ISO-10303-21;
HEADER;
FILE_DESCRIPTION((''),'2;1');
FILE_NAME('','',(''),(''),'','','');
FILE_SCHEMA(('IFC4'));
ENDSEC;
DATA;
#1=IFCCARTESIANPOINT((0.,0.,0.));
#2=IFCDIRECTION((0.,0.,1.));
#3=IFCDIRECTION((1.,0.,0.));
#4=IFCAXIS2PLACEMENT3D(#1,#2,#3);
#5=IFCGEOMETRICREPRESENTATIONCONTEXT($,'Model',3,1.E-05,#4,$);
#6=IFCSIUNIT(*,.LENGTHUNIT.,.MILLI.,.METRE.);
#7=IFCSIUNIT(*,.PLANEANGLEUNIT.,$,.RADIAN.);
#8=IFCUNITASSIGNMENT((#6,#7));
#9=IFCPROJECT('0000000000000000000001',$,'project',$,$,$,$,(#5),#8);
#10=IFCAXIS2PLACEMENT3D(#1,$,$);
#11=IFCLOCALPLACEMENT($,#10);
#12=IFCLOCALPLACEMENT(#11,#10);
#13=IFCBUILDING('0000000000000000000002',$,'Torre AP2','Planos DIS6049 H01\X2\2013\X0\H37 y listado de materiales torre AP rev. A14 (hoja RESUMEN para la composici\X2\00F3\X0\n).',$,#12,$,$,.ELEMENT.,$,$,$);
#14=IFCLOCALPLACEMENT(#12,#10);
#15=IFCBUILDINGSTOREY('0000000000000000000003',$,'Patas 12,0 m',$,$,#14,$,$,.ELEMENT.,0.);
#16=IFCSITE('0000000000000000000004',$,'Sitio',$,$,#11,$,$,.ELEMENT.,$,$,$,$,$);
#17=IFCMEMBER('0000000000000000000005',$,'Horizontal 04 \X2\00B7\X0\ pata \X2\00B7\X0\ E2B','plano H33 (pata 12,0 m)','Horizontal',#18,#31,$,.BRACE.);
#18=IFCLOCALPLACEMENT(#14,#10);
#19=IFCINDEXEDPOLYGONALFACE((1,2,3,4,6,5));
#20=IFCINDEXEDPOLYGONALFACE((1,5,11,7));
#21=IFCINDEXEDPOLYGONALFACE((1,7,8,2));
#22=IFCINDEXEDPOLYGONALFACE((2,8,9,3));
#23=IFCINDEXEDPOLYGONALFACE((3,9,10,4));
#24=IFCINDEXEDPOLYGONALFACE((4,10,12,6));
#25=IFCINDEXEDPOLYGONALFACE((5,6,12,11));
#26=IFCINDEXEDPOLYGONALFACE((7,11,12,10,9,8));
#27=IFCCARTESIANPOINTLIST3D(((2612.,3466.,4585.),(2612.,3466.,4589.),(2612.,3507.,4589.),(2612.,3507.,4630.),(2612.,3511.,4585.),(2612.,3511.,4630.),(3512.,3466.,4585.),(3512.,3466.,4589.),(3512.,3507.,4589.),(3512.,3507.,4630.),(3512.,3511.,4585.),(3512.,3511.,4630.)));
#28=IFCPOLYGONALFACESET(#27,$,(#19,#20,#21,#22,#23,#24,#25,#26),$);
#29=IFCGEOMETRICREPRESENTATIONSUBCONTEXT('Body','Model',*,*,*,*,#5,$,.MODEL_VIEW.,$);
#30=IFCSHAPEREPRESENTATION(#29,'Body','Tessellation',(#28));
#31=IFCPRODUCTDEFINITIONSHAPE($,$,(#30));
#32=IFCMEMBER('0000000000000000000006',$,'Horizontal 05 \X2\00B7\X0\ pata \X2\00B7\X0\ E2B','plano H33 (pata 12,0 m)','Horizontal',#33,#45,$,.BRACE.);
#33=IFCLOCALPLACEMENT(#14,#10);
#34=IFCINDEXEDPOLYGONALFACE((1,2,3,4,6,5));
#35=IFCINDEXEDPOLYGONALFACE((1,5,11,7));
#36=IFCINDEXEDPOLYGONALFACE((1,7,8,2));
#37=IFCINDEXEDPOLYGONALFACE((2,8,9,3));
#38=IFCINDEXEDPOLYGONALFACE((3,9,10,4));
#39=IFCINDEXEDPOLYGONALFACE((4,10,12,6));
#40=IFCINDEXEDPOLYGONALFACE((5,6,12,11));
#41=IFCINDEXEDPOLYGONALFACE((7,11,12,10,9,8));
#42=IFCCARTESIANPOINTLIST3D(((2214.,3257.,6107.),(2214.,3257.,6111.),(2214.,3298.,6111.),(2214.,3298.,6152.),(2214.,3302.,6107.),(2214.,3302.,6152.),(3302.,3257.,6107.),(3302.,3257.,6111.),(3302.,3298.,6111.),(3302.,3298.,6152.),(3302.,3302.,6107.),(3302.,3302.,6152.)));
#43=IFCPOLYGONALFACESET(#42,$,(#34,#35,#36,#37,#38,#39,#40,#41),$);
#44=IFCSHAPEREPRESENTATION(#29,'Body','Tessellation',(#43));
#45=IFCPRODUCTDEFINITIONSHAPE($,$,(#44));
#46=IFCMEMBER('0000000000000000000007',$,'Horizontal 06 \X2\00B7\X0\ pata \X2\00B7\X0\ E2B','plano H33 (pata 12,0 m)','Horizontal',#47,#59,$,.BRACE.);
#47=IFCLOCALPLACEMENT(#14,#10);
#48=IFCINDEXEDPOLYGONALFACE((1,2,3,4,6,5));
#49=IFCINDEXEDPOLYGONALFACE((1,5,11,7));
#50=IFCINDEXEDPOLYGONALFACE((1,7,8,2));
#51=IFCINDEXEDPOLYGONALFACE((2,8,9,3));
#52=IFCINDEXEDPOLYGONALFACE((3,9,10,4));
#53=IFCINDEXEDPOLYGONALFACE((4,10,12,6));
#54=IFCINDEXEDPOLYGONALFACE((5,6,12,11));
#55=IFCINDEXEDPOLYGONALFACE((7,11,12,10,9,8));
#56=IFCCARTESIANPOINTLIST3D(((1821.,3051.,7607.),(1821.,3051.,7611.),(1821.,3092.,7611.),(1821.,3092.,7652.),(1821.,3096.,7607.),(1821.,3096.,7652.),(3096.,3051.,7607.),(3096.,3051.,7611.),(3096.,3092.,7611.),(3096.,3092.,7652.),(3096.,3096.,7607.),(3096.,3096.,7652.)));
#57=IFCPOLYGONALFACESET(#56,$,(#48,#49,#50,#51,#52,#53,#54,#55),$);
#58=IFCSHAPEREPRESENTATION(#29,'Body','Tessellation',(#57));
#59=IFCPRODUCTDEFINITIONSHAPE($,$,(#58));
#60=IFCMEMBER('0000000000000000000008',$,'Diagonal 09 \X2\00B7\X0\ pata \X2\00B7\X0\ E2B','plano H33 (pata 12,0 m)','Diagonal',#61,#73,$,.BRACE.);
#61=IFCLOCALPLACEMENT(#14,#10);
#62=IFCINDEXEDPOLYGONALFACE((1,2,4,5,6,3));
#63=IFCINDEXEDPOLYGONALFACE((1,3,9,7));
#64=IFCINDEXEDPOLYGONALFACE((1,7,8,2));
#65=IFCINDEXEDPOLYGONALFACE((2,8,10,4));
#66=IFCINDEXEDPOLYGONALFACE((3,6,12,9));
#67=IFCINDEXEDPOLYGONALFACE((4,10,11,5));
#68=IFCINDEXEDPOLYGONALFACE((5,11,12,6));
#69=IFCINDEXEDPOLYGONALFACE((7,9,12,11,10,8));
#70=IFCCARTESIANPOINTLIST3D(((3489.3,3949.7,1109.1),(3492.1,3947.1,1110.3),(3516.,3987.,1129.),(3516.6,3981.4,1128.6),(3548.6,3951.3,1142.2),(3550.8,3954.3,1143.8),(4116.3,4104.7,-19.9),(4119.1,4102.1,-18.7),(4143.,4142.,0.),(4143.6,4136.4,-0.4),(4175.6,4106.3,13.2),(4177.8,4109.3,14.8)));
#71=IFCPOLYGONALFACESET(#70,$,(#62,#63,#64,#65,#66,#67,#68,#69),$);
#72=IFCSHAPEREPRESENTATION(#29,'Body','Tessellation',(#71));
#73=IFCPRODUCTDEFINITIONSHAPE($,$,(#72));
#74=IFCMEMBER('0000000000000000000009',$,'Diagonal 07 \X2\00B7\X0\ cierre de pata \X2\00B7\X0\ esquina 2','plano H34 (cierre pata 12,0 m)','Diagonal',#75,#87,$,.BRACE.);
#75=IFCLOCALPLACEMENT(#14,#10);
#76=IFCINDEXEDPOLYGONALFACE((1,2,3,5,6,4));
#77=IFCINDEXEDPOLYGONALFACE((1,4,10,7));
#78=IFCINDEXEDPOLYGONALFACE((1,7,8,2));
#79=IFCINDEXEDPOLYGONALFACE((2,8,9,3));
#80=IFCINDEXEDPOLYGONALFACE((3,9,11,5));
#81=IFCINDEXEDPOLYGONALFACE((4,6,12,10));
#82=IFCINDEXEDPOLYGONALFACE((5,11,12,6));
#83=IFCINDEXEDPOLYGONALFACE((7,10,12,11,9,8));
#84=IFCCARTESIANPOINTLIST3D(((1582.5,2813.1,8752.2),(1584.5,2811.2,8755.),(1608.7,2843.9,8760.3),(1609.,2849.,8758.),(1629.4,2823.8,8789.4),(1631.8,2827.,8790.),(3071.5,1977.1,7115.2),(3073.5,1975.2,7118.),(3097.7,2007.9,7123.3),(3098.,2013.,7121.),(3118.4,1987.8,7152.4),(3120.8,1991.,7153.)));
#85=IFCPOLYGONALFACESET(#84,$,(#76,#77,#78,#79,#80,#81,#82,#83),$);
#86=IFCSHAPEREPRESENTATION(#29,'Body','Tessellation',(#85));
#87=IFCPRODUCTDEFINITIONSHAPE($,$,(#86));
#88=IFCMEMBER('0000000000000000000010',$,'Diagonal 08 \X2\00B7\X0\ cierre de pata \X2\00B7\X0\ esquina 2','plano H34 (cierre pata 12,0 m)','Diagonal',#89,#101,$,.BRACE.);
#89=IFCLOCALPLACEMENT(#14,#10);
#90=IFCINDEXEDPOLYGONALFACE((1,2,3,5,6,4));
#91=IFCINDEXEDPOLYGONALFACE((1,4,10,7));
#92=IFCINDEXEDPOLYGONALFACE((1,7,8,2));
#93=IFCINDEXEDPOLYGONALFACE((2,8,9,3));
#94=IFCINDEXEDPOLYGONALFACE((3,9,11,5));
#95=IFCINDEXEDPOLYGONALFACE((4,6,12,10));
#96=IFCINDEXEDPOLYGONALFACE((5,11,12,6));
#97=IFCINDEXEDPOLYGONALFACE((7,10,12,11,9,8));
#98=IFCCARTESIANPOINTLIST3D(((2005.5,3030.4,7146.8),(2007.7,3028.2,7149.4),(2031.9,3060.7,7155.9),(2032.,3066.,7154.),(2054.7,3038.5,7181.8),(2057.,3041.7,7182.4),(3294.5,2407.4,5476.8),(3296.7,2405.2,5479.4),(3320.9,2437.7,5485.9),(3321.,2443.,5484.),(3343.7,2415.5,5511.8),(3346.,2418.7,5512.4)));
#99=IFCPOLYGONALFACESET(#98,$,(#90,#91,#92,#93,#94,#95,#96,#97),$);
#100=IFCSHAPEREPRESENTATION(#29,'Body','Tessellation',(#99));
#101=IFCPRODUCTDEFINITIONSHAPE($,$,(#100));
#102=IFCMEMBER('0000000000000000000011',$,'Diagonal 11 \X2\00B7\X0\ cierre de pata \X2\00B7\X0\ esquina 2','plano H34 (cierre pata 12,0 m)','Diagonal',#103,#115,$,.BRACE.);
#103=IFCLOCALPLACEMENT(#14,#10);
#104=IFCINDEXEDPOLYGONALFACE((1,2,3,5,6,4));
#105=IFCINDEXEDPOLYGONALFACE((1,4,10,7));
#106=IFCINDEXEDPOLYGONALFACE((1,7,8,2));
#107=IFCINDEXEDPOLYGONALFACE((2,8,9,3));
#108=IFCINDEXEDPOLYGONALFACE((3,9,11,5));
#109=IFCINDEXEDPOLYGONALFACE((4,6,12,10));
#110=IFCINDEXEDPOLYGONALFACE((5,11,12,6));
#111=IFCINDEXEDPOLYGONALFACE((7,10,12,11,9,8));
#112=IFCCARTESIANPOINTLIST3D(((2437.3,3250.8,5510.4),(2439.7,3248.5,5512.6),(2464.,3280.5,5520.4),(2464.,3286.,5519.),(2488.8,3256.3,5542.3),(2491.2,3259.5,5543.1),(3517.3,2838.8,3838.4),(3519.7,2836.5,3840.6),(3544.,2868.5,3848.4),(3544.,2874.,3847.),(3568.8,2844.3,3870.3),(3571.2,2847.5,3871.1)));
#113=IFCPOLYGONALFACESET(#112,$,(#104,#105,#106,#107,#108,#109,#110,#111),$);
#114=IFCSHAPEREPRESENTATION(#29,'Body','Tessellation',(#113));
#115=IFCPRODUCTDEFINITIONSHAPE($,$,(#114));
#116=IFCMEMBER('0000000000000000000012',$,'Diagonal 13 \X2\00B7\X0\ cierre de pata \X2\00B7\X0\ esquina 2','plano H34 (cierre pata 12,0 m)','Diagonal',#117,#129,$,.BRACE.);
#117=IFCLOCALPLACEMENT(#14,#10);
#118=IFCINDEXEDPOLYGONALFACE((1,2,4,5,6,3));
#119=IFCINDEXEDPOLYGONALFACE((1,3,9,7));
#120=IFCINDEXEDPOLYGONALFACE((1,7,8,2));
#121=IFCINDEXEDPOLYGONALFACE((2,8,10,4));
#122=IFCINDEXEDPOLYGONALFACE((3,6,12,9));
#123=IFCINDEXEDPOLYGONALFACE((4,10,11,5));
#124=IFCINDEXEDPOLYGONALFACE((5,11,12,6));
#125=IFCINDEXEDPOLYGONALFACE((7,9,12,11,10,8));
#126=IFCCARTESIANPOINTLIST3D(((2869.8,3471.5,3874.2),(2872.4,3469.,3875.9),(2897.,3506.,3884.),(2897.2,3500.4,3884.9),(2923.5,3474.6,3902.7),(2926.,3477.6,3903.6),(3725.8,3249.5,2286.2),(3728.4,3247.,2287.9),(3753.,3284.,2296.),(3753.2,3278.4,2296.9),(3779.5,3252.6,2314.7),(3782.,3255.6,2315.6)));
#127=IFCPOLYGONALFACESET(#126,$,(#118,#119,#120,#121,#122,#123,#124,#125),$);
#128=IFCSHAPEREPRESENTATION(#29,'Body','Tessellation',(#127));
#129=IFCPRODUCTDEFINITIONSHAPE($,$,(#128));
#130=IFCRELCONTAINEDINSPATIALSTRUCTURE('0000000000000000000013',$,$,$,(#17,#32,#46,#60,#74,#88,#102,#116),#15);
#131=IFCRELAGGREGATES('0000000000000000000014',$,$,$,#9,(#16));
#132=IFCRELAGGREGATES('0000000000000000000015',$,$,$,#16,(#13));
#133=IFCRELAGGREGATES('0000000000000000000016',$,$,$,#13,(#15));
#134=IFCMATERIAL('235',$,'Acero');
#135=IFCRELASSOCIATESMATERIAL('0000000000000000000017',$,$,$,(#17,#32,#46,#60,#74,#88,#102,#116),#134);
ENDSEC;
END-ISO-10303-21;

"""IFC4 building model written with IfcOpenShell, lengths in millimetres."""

from ifc_helpers import new_model, si_unit, frame, frame_2d, origin, origin_with_axes, place, context, subcontext, project, spatial, l_section, extrude, material, element, save


model = new_model("IFC4")

# Units and contexts
model_context = context("Model", 3, precision=1e-05, world=origin_with_axes())
body_context = subcontext(model_context, "Body", "Model", "MODEL_VIEW")
ifc_project = project(units=[si_unit("LENGTHUNIT", "METRE", prefix="MILLI"), si_unit("PLANEANGLEUNIT", "RADIAN")], contexts=[model_context])

# Site, building, storey
site_placement = place(None, origin())
site = spatial("IfcSite", under=ifc_project, at=site_placement, Name="Sitio", CompositionType="ELEMENT")
building_placement = place(site_placement, origin())
building = spatial("IfcBuilding", under=site, at=building_placement, Name="Torre AP2", Description="Planos DIS6049 H01–H37 y listado de materiales torre AP rev. A14 (hoja RESUMEN para la composición).", CompositionType="ELEMENT")
storey_placement = place(building_placement, origin())
storey = spatial("IfcBuildingStorey", under=building, at=storey_placement, Name="Patas 12,0 m", CompositionType="ELEMENT", Elevation=0.0)

# Members
ifc_material_1 = material(Name="235", Category="Acero")
member_1_placement = place(storey_placement, frame((3512.0, 3511.0, 4585.0), z_axis=(-1.0, 0.0, 0.0), x_axis=(0.0, -1.0, 0.0)))
element("IfcMember", 1, at=member_1_placement, inside=storey, material=ifc_material_1, Name="Horizontal 04 · pata · E2B", Description="plano H33 (pata 12,0 m)", ObjectType="Horizontal", PredefinedType="BRACE", context=body_context, shape_type="SweptSolid", body=[
    extrude(l_section(Depth=45.0, Width=45.0, Thickness=4.0, at=frame_2d((22.5, 22.5))), None, (0.0, 0.0, 1.0), 900.0),
])
member_2_placement = place(storey_placement, frame((3302.0, 3302.0, 6107.0), z_axis=(-1.0, 0.0, 0.0), x_axis=(0.0, -1.0, 0.0)))
element("IfcMember", 2, at=member_2_placement, inside=storey, material=ifc_material_1, Name="Horizontal 05 · pata · E2B", Description="plano H33 (pata 12,0 m)", ObjectType="Horizontal", PredefinedType="BRACE", context=body_context, shape_type="SweptSolid", body=[
    extrude(l_section(Depth=45.0, Width=45.0, Thickness=4.0, at=frame_2d((22.5, 22.5))), None, (0.0, 0.0, 1.0), 1088.0),
])
member_3_placement = place(storey_placement, frame((3096.0, 3096.0, 7607.0), z_axis=(-1.0, 0.0, 0.0), x_axis=(0.0, -1.0, 0.0)))
element("IfcMember", 3, at=member_3_placement, inside=storey, material=ifc_material_1, Name="Horizontal 06 · pata · E2B", Description="plano H33 (pata 12,0 m)", ObjectType="Horizontal", PredefinedType="BRACE", context=body_context, shape_type="SweptSolid", body=[
    extrude(l_section(Depth=45.0, Width=45.0, Thickness=4.0, at=frame_2d((22.5, 22.5))), None, (0.0, 0.0, 1.0), 1275.0),
])
member_4_placement = place(storey_placement, frame((4143.0, 4142.0, 0.0), z_axis=(-0.482052, -0.119168, 0.868001), x_axis=(-0.53324, -0.746182, -0.398583)))
element("IfcMember", 4, at=member_4_placement, inside=storey, material=ifc_material_1, Name="Diagonal 09 · pata · E2B", Description="plano H33 (pata 12,0 m)", ObjectType="Diagonal", PredefinedType="BRACE", context=body_context, shape_type="SweptSolid", body=[
    extrude(l_section(Depth=50.0, Width=50.0, Thickness=4.0, at=frame_2d((25.0, 25.0))), None, (0.0, 0.0, 1.0), 1300.7),
])
member_5_placement = place(storey_placement, frame((3098.0, 2013.0, 7121.0), z_axis=(-0.629454, 0.353407, 0.692019), x_axis=(-0.589858, -0.797058, -0.12948)))
element("IfcMember", 5, at=member_5_placement, inside=storey, material=ifc_material_1, Name="Diagonal 07 · cierre de pata · esquina 2", Description="plano H34 (cierre pata 12,0 m)", ObjectType="Diagonal", PredefinedType="BRACE", context=body_context, shape_type="SweptSolid", body=[
    extrude(l_section(Depth=45.0, Width=45.0, Thickness=4.0, at=frame_2d((22.5, 22.5))), None, (0.0, 0.0, 1.0), 2365.5),
])
member_6_placement = place(storey_placement, frame((3321.0, 2443.0, 5484.0), z_axis=(-0.585997, 0.283224, 0.759205), x_axis=(-0.58915, -0.792183, -0.159212)))
element("IfcMember", 6, at=member_6_placement, inside=storey, material=ifc_material_1, Name="Diagonal 08 · cierre de pata · esquina 2", Description="plano H34 (cierre pata 12,0 m)", ObjectType="Diagonal", PredefinedType="BRACE", context=body_context, shape_type="SweptSolid", body=[
    extrude(l_section(Depth=45.0, Width=45.0, Thickness=4.0, at=frame_2d((22.5, 22.5))), None, (0.0, 0.0, 1.0), 2199.7),
])
member_7_placement = place(storey_placement, frame((3544.0, 2874.0, 3847.0), z_axis=(-0.531322, 0.20269, 0.822565), x_axis=(-0.593545, -0.781874, -0.190728)))
element("IfcMember", 7, at=member_7_placement, inside=storey, material=ifc_material_1, Name="Diagonal 11 · cierre de pata · esquina 2", Description="plano H34 (cierre pata 12,0 m)", ObjectType="Diagonal", PredefinedType="BRACE", context=body_context, shape_type="SweptSolid", body=[
    extrude(l_section(Depth=45.0, Width=45.0, Thickness=4.0, at=frame_2d((22.5, 22.5))), None, (0.0, 0.0, 1.0), 2032.7),
])
member_8_placement = place(storey_placement, frame((3753.0, 3284.0, 2296.0), z_axis=(-0.470944, 0.122137, 0.873667), x_axis=(-0.603592, -0.766867, -0.218155)))
element("IfcMember", 8, at=member_8_placement, inside=storey, material=ifc_material_1, Name="Diagonal 13 · cierre de pata · esquina 2", Description="plano H34 (cierre pata 12,0 m)", ObjectType="Diagonal", PredefinedType="BRACE", context=body_context, shape_type="SweptSolid", body=[
    extrude(l_section(Depth=45.0, Width=45.0, Thickness=4.0, at=frame_2d((22.5, 22.5))), None, (0.0, 0.0, 1.0), 1817.6),
])

save(model, "model.ifc")
